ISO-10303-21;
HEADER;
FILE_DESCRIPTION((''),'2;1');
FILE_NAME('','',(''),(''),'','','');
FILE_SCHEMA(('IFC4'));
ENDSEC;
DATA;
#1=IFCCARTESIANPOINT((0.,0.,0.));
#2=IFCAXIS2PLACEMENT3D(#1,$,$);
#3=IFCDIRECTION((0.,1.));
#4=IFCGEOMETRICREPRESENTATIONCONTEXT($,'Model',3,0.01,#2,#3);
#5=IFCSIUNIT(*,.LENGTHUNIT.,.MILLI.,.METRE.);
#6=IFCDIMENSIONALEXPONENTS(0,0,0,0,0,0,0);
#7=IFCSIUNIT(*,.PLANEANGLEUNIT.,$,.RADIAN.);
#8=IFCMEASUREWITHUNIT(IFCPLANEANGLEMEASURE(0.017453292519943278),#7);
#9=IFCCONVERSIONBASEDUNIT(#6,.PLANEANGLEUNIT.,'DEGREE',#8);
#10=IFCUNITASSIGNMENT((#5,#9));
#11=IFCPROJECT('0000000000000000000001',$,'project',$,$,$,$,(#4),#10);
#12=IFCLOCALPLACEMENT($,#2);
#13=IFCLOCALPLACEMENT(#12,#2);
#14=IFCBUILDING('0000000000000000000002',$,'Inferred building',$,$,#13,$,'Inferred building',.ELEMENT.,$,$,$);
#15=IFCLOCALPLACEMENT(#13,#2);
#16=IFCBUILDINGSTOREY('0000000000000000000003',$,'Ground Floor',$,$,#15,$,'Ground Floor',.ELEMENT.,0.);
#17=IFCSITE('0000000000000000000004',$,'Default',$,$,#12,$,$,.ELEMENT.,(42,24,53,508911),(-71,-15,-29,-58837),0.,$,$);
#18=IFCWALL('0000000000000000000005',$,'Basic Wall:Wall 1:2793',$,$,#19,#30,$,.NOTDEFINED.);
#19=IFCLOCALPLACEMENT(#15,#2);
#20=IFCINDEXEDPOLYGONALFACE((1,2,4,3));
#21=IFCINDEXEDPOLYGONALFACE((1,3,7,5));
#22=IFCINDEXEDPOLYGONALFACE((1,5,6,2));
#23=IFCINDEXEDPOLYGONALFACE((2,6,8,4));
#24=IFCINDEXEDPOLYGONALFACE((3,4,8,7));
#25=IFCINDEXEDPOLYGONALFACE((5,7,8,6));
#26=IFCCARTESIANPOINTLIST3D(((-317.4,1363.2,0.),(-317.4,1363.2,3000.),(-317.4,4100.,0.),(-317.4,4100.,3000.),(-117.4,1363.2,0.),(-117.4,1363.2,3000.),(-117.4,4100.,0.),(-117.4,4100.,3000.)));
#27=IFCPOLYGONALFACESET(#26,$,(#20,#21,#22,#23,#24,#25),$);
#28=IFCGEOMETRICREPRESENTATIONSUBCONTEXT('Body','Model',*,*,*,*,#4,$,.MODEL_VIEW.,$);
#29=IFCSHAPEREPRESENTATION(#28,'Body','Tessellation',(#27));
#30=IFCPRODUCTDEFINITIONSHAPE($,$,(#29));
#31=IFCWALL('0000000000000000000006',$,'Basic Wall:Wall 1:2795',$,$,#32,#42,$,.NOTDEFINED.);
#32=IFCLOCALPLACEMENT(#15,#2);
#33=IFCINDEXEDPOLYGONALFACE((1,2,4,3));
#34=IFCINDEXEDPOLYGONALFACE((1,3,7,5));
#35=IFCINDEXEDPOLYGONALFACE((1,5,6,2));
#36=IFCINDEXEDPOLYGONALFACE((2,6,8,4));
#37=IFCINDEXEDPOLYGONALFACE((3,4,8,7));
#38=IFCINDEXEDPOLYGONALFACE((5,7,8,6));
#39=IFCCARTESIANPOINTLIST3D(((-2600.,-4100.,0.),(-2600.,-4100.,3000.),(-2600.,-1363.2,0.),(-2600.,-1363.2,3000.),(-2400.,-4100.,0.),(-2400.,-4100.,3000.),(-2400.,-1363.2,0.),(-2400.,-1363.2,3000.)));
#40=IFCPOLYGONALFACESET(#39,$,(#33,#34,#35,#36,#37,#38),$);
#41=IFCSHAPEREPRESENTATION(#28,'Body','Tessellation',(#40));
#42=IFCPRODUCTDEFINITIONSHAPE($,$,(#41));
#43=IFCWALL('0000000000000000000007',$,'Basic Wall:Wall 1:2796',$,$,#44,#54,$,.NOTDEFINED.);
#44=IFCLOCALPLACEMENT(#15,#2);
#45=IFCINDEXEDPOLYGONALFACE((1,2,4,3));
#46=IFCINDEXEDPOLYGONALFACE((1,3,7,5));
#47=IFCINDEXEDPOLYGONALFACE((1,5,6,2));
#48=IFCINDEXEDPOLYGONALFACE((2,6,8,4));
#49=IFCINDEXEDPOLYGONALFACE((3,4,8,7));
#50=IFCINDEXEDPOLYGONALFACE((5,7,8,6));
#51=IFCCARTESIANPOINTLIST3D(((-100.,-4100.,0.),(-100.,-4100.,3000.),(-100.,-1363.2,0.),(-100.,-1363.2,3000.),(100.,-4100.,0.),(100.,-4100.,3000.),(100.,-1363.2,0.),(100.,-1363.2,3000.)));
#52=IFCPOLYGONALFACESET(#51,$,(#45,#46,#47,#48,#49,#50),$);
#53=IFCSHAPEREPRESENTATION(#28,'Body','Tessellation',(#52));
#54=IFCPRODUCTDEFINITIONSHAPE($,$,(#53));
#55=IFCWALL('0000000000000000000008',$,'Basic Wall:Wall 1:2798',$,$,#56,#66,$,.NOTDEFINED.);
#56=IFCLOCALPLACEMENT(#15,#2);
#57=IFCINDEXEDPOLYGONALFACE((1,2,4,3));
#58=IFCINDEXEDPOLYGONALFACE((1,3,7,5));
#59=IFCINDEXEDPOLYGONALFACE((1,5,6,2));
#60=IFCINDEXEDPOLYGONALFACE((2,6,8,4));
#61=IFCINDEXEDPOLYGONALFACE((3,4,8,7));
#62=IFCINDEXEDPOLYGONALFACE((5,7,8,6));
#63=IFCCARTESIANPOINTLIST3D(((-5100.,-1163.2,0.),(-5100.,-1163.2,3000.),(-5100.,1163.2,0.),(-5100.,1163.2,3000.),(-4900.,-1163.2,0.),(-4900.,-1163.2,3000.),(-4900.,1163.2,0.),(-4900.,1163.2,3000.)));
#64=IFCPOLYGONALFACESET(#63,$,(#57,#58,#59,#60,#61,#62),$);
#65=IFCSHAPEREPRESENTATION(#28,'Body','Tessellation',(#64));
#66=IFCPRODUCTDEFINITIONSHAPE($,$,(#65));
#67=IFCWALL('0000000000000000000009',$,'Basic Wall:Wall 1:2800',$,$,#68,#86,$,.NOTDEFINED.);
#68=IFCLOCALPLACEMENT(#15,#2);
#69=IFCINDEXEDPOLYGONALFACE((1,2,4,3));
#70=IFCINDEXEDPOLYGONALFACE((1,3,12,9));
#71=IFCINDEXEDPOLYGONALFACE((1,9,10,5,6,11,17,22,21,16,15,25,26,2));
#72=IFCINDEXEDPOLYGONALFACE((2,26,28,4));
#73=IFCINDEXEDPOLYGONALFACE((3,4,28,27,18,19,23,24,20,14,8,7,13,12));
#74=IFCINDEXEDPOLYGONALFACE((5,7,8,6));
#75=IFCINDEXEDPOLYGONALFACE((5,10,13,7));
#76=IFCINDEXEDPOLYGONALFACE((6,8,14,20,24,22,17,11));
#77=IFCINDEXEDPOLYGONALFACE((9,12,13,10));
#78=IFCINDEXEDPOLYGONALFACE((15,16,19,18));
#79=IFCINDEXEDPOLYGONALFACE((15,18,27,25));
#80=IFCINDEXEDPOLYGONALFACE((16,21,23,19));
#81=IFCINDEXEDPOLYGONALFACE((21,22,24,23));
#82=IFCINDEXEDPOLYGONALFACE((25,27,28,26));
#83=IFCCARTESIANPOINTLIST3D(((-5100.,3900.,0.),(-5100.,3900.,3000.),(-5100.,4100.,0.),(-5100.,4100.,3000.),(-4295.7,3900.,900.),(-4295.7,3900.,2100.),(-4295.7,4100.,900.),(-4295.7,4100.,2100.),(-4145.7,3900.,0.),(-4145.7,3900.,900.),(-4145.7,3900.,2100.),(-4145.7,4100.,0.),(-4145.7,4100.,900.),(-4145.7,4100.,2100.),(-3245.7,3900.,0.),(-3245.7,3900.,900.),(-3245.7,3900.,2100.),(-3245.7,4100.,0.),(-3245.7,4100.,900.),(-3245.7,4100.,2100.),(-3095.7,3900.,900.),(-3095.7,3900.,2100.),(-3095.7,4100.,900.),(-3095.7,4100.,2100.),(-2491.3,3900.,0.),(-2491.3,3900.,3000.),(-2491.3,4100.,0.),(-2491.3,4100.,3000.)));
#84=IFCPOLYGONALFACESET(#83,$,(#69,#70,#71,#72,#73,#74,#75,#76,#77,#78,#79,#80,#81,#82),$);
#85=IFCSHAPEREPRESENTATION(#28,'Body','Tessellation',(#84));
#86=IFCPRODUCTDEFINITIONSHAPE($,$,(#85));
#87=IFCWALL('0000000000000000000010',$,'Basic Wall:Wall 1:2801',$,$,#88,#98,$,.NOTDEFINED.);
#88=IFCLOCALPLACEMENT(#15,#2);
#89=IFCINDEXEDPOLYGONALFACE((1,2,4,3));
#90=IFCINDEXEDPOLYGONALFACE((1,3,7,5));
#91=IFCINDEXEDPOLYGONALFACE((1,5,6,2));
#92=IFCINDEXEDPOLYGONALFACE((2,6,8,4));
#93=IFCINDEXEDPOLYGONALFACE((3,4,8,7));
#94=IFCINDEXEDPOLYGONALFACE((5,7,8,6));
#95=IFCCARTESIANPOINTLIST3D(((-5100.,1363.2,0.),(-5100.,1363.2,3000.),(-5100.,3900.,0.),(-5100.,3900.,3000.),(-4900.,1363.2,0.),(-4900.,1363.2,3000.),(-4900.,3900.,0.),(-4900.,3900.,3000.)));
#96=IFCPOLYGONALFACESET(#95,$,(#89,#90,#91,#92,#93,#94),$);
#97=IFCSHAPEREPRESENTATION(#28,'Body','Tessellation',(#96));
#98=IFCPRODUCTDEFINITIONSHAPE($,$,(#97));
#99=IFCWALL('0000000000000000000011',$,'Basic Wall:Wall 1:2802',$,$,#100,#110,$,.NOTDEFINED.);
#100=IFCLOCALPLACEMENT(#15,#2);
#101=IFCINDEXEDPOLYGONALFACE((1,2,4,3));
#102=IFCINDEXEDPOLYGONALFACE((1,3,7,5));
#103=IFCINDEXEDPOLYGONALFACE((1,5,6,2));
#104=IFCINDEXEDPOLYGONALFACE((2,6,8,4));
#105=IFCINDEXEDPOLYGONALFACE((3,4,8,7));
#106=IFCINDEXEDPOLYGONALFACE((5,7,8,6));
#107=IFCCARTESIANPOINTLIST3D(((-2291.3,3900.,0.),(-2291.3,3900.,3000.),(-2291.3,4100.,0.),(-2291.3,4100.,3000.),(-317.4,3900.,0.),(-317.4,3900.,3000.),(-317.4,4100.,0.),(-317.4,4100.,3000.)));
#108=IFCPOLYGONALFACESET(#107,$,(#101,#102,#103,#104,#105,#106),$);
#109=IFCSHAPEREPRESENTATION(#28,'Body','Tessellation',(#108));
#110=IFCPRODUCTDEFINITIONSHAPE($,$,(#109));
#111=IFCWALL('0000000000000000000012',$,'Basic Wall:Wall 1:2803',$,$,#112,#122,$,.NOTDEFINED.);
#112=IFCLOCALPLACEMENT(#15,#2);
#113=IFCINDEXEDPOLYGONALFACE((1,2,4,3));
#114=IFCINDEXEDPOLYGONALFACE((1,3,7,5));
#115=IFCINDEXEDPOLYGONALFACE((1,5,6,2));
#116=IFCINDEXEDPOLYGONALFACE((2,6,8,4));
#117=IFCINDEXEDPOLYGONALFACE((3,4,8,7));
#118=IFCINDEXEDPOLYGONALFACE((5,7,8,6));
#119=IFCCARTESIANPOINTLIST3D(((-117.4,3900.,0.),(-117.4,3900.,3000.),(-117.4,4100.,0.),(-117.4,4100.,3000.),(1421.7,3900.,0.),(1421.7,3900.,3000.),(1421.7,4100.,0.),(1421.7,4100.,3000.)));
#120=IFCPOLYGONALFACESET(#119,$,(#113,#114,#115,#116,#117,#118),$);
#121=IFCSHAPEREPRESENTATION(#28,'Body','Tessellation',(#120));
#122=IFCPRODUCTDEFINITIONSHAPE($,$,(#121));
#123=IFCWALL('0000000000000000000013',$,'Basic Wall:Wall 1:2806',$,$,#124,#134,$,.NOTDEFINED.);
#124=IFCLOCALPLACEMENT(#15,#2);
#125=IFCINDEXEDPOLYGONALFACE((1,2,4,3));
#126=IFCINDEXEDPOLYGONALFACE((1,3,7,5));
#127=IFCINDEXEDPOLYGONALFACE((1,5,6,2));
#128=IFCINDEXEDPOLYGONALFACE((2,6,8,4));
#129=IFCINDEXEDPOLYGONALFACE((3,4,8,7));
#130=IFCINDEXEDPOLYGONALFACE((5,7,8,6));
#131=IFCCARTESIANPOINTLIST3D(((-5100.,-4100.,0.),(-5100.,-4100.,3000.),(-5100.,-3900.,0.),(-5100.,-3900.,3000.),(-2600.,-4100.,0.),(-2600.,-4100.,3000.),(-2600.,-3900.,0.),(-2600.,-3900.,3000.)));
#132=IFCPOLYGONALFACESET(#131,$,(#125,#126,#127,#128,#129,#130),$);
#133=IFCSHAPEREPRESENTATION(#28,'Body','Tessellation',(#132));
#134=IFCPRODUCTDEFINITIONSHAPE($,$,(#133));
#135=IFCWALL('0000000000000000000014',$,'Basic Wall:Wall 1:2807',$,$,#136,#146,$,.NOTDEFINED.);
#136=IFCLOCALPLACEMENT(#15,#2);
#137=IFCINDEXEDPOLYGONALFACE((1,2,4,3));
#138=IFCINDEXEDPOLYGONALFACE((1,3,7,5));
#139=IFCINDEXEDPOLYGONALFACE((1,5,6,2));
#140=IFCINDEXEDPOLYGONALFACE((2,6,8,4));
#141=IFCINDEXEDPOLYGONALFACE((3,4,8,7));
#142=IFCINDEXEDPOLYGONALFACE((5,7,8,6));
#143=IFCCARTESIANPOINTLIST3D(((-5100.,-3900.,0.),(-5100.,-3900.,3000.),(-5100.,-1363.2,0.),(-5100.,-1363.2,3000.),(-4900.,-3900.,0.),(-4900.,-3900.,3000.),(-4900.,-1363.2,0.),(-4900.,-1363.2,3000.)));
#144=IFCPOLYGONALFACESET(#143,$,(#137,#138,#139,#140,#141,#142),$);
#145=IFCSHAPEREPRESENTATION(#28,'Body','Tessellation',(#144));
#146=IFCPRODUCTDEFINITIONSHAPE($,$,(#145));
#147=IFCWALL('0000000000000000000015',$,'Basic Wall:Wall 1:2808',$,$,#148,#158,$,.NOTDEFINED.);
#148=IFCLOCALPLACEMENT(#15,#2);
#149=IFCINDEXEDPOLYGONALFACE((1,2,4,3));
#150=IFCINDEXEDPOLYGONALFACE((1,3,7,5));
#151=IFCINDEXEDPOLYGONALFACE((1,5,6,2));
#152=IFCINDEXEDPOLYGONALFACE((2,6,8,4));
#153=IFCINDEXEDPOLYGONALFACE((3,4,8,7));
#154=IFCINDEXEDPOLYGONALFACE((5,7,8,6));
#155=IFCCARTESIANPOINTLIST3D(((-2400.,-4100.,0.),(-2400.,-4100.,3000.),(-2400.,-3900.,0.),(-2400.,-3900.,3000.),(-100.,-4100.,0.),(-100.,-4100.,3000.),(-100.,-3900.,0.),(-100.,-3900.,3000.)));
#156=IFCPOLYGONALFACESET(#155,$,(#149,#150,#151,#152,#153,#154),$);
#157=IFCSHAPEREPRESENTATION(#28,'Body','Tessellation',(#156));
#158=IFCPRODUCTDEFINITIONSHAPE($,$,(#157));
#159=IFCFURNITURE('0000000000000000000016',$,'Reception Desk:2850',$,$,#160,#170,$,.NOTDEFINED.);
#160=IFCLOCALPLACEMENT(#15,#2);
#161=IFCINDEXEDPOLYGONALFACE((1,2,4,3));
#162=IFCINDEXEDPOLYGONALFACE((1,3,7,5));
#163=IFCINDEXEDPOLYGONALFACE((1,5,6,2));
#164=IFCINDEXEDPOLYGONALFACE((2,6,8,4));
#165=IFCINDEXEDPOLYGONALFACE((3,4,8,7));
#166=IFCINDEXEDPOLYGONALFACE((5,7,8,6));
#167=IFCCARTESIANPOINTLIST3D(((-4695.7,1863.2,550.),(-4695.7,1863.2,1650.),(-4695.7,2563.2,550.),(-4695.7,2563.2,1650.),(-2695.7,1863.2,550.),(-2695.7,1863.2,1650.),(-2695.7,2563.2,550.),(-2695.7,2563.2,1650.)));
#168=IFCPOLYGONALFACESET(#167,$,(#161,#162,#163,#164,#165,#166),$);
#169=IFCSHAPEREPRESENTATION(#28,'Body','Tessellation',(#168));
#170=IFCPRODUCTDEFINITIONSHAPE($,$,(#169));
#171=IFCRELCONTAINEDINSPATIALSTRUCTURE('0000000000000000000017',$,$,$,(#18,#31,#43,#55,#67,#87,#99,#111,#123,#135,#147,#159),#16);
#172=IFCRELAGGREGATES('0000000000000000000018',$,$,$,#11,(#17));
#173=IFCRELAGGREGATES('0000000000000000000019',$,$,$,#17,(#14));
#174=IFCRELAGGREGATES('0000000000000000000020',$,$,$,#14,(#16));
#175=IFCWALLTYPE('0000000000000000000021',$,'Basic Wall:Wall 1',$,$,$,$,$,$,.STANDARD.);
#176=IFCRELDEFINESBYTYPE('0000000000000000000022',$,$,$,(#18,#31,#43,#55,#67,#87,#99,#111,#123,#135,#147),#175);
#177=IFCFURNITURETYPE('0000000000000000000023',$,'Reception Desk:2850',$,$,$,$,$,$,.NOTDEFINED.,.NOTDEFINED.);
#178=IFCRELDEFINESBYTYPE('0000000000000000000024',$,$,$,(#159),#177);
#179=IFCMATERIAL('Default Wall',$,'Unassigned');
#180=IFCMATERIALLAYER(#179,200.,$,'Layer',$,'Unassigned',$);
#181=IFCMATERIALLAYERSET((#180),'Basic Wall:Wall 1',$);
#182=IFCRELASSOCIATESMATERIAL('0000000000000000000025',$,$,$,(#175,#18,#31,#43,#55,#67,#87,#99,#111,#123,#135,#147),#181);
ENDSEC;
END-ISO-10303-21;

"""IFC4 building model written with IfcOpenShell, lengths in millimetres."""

from ifc_helpers import new_model, entity, si_unit, converted_unit, direction, frame, frame_2d, origin, origin_2d_with_axis, place, context, subcontext, project, spatial, rectangle, extrude, material, layer, layer_set, layer_usage, type_object, element, save


model = new_model("IFC4")

# Units and contexts
model_context = context("Model", 3, precision=0.01, world=origin(), true_north=direction((0.0, 1.0)))
body_context = subcontext(model_context, "Body", "Model", "MODEL_VIEW")
ifc_project = project(units=[si_unit("LENGTHUNIT", "METRE", prefix="MILLI"), converted_unit("PLANEANGLEUNIT", "DEGREE", entity("IfcPlaneAngleMeasure", 0.017453292519943278), si_unit("PLANEANGLEUNIT", "RADIAN"), dimensions=[0, 0, 0, 0, 0, 0, 0])], contexts=[model_context])

# Site, building, storey
site_placement = place(None, origin())
site = spatial("IfcSite", under=ifc_project, at=site_placement, Name="Default", CompositionType="ELEMENT", RefLatitude=(42, 24, 53, 508911), RefLongitude=(-71, -15, -29, -58837), RefElevation=0.0)
building_placement = place(site_placement, origin())
building = spatial("IfcBuilding", under=site, at=building_placement, Name="Inferred building", LongName="Inferred building", CompositionType="ELEMENT")
storey_placement = place(building_placement, origin())
storey = spatial("IfcBuildingStorey", under=building, at=storey_placement, Name="Ground Floor", LongName="Ground Floor", CompositionType="ELEMENT", Elevation=0.0)

# Shared definitions
ifc_material_1 = material(Name="Default Wall", Category="Unassigned")
ifc_layer_1 = layer(ifc_material_1, 200.0, Name="Layer", Category="Unassigned")
ifc_layer_set_1 = layer_set([ifc_layer_1], Name="Basic Wall:Wall 1")
wall_type = type_object("IfcWallType", Name="Basic Wall:Wall 1", PredefinedType="STANDARD", material=ifc_layer_set_1)

# Walls
ifc_layer_usage_1 = layer_usage(ifc_layer_set_1, "AXIS2", "NEGATIVE", 100.0)
wall_1_placement = place(storey_placement, frame((-217.4, 1363.2, 0.0), z_axis=(0.0, 0.0, 1.0), x_axis=(0.0, 1.0, 0.0)))
element("IfcWall", 1, at=wall_1_placement, inside=storey, type_object=wall_type, material=ifc_layer_usage_1, Name="Basic Wall:Wall 1:2793", PredefinedType="NOTDEFINED", context=body_context, shape_type="SweptSolid", body=[
    extrude(rectangle(XDim=2736.8, YDim=200.0, at=frame_2d((1368.4, 0.0), x_axis=(-1.0, 0.0))), origin(), (0.0, 0.0, 1.0), 3000.0),
])
ifc_layer_usage_2 = layer_usage(ifc_layer_set_1, "AXIS2", "NEGATIVE", 100.0)
wall_2_placement = place(storey_placement, frame((-2500.0, -4100.0, 0.0), z_axis=(0.0, 0.0, 1.0), x_axis=(0.0, 1.0, 0.0)))
element("IfcWall", 2, at=wall_2_placement, inside=storey, type_object=wall_type, material=ifc_layer_usage_2, Name="Basic Wall:Wall 1:2795", PredefinedType="NOTDEFINED", context=body_context, shape_type="SweptSolid", body=[
    extrude(rectangle(XDim=2736.8, YDim=200.0, at=frame_2d((1368.4, 0.0), x_axis=(-1.0, 0.0))), origin(), (0.0, 0.0, 1.0), 3000.0),
])
ifc_layer_usage_3 = layer_usage(ifc_layer_set_1, "AXIS2", "NEGATIVE", 100.0)
wall_3_placement = place(storey_placement, frame((0.0, -4100.0, 0.0), z_axis=(0.0, 0.0, 1.0), x_axis=(0.0, 1.0, 0.0)))
element("IfcWall", 3, at=wall_3_placement, inside=storey, type_object=wall_type, material=ifc_layer_usage_3, Name="Basic Wall:Wall 1:2796", PredefinedType="NOTDEFINED", context=body_context, shape_type="SweptSolid", body=[
    extrude(rectangle(XDim=2736.8, YDim=200.0, at=frame_2d((1368.4, 0.0), x_axis=(-1.0, 0.0))), origin(), (0.0, 0.0, 1.0), 3000.0),
])
ifc_layer_usage_4 = layer_usage(ifc_layer_set_1, "AXIS2", "NEGATIVE", 100.0)
wall_4_placement = place(storey_placement, frame((-5000.0, -1163.2, 0.0), z_axis=(0.0, 0.0, 1.0), x_axis=(0.0, 1.0, 0.0)))
element("IfcWall", 4, at=wall_4_placement, inside=storey, type_object=wall_type, material=ifc_layer_usage_4, Name="Basic Wall:Wall 1:2798", PredefinedType="NOTDEFINED", context=body_context, shape_type="SweptSolid", body=[
    extrude(rectangle(XDim=2326.3, YDim=200.0, at=frame_2d((1163.2, 0.0), x_axis=(-1.0, 0.0))), origin(), (0.0, 0.0, 1.0), 3000.0),
])

# Wall, openings
ifc_layer_usage_5 = layer_usage(ifc_layer_set_1, "AXIS2", "NEGATIVE", 100.0)
wall_5_placement = place(storey_placement, frame((-5100.0, 4000.0, 0.0)))
wall_5 = element("IfcWall", 5, at=wall_5_placement, inside=storey, type_object=wall_type, material=ifc_layer_usage_5, Name="Basic Wall:Wall 1:2800", PredefinedType="NOTDEFINED", context=body_context, shape_type="SweptSolid", body=[
    extrude(rectangle(XDim=2608.7, YDim=200.0, at=frame_2d((1304.3, 0.0), x_axis=(1.0, 0.0))), origin(), (0.0, 0.0, 1.0), 3000.0),
])
opening_1_placement = place(wall_5_placement, origin())
element("IfcOpeningElement", 6, at=opening_1_placement, cuts=wall_5, PredefinedType="OPENING", context=body_context, shape_type="SweptSolid", body=[
    extrude(rectangle(XDim=2100.0, YDim=900.0, at=origin_2d_with_axis()), frame((1404.3, -100.0, 1050.0), z_axis=(0.0, 1.0, 0.0), x_axis=(0.0, 0.0, -1.0)), (0.0, 0.0, 1.0), 200.0),
])
opening_2_placement = place(wall_5_placement, origin())
element("IfcOpeningElement", 7, at=opening_2_placement, cuts=wall_5, PredefinedType="OPENING", context=body_context, shape_type="SweptSolid", body=[
    extrude(rectangle(XDim=1200.0, YDim=1200.0, at=frame_2d((0.0, 0.0), x_axis=(1.0, 0.0))), frame((1404.3, -100.0, 1500.0), z_axis=(0.0, 1.0, 0.0), x_axis=(0.0, 0.0, -1.0)), (0.0, 0.0, 1.0), 200.0),
])

# Walls
ifc_layer_usage_6 = layer_usage(ifc_layer_set_1, "AXIS2", "NEGATIVE", 100.0)
wall_6_placement = place(storey_placement, frame((-5000.0, 1363.2, 0.0), z_axis=(0.0, 0.0, 1.0), x_axis=(0.0, 1.0, 0.0)))
element("IfcWall", 8, at=wall_6_placement, inside=storey, type_object=wall_type, material=ifc_layer_usage_6, Name="Basic Wall:Wall 1:2801", PredefinedType="NOTDEFINED", context=body_context, shape_type="SweptSolid", body=[
    extrude(rectangle(XDim=2536.8, YDim=200.0, at=frame_2d((1268.4, 0.0), x_axis=(-1.0, 0.0))), origin(), (0.0, 0.0, 1.0), 3000.0),
])
ifc_layer_usage_7 = layer_usage(ifc_layer_set_1, "AXIS2", "NEGATIVE", 100.0)
wall_7_placement = place(storey_placement, frame((-2291.3, 4000.0, 0.0)))
element("IfcWall", 9, at=wall_7_placement, inside=storey, type_object=wall_type, material=ifc_layer_usage_7, Name="Basic Wall:Wall 1:2802", PredefinedType="NOTDEFINED", context=body_context, shape_type="SweptSolid", body=[
    extrude(rectangle(XDim=1973.9, YDim=200.0, at=frame_2d((987.0, 0.0), x_axis=(-1.0, 0.0))), origin(), (0.0, 0.0, 1.0), 3000.0),
])
ifc_layer_usage_8 = layer_usage(ifc_layer_set_1, "AXIS2", "NEGATIVE", 100.0)
wall_8_placement = place(storey_placement, frame((-117.4, 4000.0, 0.0)))
element("IfcWall", 10, at=wall_8_placement, inside=storey, type_object=wall_type, material=ifc_layer_usage_8, Name="Basic Wall:Wall 1:2803", PredefinedType="NOTDEFINED", context=body_context, shape_type="SweptSolid", body=[
    extrude(rectangle(XDim=1539.1, YDim=200.0, at=frame_2d((769.6, 0.0), x_axis=(-1.0, 0.0))), origin(), (0.0, 0.0, 1.0), 3000.0),
])
ifc_layer_usage_9 = layer_usage(ifc_layer_set_1, "AXIS2", "NEGATIVE", 100.0)
wall_9_placement = place(storey_placement, frame((-5100.0, -4000.0, 0.0)))
element("IfcWall", 11, at=wall_9_placement, inside=storey, type_object=wall_type, material=ifc_layer_usage_9, Name="Basic Wall:Wall 1:2806", PredefinedType="NOTDEFINED", context=body_context, shape_type="SweptSolid", body=[
    extrude(rectangle(XDim=2500.0, YDim=200.0, at=frame_2d((1250.0, 0.0), x_axis=(-1.0, 0.0))), origin(), (0.0, 0.0, 1.0), 3000.0),
])
ifc_layer_usage_10 = layer_usage(ifc_layer_set_1, "AXIS2", "NEGATIVE", 100.0)
wall_10_placement = place(storey_placement, frame((-5000.0, -3900.0, 0.0), z_axis=(0.0, 0.0, 1.0), x_axis=(0.0, 1.0, 0.0)))
element("IfcWall", 12, at=wall_10_placement, inside=storey, type_object=wall_type, material=ifc_layer_usage_10, Name="Basic Wall:Wall 1:2807", PredefinedType="NOTDEFINED", context=body_context, shape_type="SweptSolid", body=[
    extrude(rectangle(XDim=2536.8, YDim=200.0, at=frame_2d((1268.4, 0.0), x_axis=(-1.0, 0.0))), origin(), (0.0, 0.0, 1.0), 3000.0),
])
ifc_layer_usage_11 = layer_usage(ifc_layer_set_1, "AXIS2", "NEGATIVE", 100.0)
wall_11_placement = place(storey_placement, frame((-2400.0, -4000.0, 0.0)))
element("IfcWall", 13, at=wall_11_placement, inside=storey, type_object=wall_type, material=ifc_layer_usage_11, Name="Basic Wall:Wall 1:2808", PredefinedType="NOTDEFINED", context=body_context, shape_type="SweptSolid", body=[
    extrude(rectangle(XDim=2300.0, YDim=200.0, at=frame_2d((1150.0, 0.0), x_axis=(-1.0, 0.0))), origin(), (0.0, 0.0, 1.0), 3000.0),
])

# Furniture
furniture_type = type_object("IfcFurnitureType", Name="Reception Desk:2850", PredefinedType="NOTDEFINED")
furniture_placement = place(storey_placement, origin())
element("IfcFurniture", 14, at=furniture_placement, inside=storey, type_object=furniture_type, Name="Reception Desk:2850", PredefinedType="NOTDEFINED", context=body_context, shape_type="SweptSolid", body=[
    extrude(rectangle(XDim=2000.0, YDim=700.0, at=origin_2d_with_axis()), frame((-3695.7, 2213.2, 550.0)), (0.0, 0.0, 1.0), 1100.0),
])

save(model, "model.ifc")
